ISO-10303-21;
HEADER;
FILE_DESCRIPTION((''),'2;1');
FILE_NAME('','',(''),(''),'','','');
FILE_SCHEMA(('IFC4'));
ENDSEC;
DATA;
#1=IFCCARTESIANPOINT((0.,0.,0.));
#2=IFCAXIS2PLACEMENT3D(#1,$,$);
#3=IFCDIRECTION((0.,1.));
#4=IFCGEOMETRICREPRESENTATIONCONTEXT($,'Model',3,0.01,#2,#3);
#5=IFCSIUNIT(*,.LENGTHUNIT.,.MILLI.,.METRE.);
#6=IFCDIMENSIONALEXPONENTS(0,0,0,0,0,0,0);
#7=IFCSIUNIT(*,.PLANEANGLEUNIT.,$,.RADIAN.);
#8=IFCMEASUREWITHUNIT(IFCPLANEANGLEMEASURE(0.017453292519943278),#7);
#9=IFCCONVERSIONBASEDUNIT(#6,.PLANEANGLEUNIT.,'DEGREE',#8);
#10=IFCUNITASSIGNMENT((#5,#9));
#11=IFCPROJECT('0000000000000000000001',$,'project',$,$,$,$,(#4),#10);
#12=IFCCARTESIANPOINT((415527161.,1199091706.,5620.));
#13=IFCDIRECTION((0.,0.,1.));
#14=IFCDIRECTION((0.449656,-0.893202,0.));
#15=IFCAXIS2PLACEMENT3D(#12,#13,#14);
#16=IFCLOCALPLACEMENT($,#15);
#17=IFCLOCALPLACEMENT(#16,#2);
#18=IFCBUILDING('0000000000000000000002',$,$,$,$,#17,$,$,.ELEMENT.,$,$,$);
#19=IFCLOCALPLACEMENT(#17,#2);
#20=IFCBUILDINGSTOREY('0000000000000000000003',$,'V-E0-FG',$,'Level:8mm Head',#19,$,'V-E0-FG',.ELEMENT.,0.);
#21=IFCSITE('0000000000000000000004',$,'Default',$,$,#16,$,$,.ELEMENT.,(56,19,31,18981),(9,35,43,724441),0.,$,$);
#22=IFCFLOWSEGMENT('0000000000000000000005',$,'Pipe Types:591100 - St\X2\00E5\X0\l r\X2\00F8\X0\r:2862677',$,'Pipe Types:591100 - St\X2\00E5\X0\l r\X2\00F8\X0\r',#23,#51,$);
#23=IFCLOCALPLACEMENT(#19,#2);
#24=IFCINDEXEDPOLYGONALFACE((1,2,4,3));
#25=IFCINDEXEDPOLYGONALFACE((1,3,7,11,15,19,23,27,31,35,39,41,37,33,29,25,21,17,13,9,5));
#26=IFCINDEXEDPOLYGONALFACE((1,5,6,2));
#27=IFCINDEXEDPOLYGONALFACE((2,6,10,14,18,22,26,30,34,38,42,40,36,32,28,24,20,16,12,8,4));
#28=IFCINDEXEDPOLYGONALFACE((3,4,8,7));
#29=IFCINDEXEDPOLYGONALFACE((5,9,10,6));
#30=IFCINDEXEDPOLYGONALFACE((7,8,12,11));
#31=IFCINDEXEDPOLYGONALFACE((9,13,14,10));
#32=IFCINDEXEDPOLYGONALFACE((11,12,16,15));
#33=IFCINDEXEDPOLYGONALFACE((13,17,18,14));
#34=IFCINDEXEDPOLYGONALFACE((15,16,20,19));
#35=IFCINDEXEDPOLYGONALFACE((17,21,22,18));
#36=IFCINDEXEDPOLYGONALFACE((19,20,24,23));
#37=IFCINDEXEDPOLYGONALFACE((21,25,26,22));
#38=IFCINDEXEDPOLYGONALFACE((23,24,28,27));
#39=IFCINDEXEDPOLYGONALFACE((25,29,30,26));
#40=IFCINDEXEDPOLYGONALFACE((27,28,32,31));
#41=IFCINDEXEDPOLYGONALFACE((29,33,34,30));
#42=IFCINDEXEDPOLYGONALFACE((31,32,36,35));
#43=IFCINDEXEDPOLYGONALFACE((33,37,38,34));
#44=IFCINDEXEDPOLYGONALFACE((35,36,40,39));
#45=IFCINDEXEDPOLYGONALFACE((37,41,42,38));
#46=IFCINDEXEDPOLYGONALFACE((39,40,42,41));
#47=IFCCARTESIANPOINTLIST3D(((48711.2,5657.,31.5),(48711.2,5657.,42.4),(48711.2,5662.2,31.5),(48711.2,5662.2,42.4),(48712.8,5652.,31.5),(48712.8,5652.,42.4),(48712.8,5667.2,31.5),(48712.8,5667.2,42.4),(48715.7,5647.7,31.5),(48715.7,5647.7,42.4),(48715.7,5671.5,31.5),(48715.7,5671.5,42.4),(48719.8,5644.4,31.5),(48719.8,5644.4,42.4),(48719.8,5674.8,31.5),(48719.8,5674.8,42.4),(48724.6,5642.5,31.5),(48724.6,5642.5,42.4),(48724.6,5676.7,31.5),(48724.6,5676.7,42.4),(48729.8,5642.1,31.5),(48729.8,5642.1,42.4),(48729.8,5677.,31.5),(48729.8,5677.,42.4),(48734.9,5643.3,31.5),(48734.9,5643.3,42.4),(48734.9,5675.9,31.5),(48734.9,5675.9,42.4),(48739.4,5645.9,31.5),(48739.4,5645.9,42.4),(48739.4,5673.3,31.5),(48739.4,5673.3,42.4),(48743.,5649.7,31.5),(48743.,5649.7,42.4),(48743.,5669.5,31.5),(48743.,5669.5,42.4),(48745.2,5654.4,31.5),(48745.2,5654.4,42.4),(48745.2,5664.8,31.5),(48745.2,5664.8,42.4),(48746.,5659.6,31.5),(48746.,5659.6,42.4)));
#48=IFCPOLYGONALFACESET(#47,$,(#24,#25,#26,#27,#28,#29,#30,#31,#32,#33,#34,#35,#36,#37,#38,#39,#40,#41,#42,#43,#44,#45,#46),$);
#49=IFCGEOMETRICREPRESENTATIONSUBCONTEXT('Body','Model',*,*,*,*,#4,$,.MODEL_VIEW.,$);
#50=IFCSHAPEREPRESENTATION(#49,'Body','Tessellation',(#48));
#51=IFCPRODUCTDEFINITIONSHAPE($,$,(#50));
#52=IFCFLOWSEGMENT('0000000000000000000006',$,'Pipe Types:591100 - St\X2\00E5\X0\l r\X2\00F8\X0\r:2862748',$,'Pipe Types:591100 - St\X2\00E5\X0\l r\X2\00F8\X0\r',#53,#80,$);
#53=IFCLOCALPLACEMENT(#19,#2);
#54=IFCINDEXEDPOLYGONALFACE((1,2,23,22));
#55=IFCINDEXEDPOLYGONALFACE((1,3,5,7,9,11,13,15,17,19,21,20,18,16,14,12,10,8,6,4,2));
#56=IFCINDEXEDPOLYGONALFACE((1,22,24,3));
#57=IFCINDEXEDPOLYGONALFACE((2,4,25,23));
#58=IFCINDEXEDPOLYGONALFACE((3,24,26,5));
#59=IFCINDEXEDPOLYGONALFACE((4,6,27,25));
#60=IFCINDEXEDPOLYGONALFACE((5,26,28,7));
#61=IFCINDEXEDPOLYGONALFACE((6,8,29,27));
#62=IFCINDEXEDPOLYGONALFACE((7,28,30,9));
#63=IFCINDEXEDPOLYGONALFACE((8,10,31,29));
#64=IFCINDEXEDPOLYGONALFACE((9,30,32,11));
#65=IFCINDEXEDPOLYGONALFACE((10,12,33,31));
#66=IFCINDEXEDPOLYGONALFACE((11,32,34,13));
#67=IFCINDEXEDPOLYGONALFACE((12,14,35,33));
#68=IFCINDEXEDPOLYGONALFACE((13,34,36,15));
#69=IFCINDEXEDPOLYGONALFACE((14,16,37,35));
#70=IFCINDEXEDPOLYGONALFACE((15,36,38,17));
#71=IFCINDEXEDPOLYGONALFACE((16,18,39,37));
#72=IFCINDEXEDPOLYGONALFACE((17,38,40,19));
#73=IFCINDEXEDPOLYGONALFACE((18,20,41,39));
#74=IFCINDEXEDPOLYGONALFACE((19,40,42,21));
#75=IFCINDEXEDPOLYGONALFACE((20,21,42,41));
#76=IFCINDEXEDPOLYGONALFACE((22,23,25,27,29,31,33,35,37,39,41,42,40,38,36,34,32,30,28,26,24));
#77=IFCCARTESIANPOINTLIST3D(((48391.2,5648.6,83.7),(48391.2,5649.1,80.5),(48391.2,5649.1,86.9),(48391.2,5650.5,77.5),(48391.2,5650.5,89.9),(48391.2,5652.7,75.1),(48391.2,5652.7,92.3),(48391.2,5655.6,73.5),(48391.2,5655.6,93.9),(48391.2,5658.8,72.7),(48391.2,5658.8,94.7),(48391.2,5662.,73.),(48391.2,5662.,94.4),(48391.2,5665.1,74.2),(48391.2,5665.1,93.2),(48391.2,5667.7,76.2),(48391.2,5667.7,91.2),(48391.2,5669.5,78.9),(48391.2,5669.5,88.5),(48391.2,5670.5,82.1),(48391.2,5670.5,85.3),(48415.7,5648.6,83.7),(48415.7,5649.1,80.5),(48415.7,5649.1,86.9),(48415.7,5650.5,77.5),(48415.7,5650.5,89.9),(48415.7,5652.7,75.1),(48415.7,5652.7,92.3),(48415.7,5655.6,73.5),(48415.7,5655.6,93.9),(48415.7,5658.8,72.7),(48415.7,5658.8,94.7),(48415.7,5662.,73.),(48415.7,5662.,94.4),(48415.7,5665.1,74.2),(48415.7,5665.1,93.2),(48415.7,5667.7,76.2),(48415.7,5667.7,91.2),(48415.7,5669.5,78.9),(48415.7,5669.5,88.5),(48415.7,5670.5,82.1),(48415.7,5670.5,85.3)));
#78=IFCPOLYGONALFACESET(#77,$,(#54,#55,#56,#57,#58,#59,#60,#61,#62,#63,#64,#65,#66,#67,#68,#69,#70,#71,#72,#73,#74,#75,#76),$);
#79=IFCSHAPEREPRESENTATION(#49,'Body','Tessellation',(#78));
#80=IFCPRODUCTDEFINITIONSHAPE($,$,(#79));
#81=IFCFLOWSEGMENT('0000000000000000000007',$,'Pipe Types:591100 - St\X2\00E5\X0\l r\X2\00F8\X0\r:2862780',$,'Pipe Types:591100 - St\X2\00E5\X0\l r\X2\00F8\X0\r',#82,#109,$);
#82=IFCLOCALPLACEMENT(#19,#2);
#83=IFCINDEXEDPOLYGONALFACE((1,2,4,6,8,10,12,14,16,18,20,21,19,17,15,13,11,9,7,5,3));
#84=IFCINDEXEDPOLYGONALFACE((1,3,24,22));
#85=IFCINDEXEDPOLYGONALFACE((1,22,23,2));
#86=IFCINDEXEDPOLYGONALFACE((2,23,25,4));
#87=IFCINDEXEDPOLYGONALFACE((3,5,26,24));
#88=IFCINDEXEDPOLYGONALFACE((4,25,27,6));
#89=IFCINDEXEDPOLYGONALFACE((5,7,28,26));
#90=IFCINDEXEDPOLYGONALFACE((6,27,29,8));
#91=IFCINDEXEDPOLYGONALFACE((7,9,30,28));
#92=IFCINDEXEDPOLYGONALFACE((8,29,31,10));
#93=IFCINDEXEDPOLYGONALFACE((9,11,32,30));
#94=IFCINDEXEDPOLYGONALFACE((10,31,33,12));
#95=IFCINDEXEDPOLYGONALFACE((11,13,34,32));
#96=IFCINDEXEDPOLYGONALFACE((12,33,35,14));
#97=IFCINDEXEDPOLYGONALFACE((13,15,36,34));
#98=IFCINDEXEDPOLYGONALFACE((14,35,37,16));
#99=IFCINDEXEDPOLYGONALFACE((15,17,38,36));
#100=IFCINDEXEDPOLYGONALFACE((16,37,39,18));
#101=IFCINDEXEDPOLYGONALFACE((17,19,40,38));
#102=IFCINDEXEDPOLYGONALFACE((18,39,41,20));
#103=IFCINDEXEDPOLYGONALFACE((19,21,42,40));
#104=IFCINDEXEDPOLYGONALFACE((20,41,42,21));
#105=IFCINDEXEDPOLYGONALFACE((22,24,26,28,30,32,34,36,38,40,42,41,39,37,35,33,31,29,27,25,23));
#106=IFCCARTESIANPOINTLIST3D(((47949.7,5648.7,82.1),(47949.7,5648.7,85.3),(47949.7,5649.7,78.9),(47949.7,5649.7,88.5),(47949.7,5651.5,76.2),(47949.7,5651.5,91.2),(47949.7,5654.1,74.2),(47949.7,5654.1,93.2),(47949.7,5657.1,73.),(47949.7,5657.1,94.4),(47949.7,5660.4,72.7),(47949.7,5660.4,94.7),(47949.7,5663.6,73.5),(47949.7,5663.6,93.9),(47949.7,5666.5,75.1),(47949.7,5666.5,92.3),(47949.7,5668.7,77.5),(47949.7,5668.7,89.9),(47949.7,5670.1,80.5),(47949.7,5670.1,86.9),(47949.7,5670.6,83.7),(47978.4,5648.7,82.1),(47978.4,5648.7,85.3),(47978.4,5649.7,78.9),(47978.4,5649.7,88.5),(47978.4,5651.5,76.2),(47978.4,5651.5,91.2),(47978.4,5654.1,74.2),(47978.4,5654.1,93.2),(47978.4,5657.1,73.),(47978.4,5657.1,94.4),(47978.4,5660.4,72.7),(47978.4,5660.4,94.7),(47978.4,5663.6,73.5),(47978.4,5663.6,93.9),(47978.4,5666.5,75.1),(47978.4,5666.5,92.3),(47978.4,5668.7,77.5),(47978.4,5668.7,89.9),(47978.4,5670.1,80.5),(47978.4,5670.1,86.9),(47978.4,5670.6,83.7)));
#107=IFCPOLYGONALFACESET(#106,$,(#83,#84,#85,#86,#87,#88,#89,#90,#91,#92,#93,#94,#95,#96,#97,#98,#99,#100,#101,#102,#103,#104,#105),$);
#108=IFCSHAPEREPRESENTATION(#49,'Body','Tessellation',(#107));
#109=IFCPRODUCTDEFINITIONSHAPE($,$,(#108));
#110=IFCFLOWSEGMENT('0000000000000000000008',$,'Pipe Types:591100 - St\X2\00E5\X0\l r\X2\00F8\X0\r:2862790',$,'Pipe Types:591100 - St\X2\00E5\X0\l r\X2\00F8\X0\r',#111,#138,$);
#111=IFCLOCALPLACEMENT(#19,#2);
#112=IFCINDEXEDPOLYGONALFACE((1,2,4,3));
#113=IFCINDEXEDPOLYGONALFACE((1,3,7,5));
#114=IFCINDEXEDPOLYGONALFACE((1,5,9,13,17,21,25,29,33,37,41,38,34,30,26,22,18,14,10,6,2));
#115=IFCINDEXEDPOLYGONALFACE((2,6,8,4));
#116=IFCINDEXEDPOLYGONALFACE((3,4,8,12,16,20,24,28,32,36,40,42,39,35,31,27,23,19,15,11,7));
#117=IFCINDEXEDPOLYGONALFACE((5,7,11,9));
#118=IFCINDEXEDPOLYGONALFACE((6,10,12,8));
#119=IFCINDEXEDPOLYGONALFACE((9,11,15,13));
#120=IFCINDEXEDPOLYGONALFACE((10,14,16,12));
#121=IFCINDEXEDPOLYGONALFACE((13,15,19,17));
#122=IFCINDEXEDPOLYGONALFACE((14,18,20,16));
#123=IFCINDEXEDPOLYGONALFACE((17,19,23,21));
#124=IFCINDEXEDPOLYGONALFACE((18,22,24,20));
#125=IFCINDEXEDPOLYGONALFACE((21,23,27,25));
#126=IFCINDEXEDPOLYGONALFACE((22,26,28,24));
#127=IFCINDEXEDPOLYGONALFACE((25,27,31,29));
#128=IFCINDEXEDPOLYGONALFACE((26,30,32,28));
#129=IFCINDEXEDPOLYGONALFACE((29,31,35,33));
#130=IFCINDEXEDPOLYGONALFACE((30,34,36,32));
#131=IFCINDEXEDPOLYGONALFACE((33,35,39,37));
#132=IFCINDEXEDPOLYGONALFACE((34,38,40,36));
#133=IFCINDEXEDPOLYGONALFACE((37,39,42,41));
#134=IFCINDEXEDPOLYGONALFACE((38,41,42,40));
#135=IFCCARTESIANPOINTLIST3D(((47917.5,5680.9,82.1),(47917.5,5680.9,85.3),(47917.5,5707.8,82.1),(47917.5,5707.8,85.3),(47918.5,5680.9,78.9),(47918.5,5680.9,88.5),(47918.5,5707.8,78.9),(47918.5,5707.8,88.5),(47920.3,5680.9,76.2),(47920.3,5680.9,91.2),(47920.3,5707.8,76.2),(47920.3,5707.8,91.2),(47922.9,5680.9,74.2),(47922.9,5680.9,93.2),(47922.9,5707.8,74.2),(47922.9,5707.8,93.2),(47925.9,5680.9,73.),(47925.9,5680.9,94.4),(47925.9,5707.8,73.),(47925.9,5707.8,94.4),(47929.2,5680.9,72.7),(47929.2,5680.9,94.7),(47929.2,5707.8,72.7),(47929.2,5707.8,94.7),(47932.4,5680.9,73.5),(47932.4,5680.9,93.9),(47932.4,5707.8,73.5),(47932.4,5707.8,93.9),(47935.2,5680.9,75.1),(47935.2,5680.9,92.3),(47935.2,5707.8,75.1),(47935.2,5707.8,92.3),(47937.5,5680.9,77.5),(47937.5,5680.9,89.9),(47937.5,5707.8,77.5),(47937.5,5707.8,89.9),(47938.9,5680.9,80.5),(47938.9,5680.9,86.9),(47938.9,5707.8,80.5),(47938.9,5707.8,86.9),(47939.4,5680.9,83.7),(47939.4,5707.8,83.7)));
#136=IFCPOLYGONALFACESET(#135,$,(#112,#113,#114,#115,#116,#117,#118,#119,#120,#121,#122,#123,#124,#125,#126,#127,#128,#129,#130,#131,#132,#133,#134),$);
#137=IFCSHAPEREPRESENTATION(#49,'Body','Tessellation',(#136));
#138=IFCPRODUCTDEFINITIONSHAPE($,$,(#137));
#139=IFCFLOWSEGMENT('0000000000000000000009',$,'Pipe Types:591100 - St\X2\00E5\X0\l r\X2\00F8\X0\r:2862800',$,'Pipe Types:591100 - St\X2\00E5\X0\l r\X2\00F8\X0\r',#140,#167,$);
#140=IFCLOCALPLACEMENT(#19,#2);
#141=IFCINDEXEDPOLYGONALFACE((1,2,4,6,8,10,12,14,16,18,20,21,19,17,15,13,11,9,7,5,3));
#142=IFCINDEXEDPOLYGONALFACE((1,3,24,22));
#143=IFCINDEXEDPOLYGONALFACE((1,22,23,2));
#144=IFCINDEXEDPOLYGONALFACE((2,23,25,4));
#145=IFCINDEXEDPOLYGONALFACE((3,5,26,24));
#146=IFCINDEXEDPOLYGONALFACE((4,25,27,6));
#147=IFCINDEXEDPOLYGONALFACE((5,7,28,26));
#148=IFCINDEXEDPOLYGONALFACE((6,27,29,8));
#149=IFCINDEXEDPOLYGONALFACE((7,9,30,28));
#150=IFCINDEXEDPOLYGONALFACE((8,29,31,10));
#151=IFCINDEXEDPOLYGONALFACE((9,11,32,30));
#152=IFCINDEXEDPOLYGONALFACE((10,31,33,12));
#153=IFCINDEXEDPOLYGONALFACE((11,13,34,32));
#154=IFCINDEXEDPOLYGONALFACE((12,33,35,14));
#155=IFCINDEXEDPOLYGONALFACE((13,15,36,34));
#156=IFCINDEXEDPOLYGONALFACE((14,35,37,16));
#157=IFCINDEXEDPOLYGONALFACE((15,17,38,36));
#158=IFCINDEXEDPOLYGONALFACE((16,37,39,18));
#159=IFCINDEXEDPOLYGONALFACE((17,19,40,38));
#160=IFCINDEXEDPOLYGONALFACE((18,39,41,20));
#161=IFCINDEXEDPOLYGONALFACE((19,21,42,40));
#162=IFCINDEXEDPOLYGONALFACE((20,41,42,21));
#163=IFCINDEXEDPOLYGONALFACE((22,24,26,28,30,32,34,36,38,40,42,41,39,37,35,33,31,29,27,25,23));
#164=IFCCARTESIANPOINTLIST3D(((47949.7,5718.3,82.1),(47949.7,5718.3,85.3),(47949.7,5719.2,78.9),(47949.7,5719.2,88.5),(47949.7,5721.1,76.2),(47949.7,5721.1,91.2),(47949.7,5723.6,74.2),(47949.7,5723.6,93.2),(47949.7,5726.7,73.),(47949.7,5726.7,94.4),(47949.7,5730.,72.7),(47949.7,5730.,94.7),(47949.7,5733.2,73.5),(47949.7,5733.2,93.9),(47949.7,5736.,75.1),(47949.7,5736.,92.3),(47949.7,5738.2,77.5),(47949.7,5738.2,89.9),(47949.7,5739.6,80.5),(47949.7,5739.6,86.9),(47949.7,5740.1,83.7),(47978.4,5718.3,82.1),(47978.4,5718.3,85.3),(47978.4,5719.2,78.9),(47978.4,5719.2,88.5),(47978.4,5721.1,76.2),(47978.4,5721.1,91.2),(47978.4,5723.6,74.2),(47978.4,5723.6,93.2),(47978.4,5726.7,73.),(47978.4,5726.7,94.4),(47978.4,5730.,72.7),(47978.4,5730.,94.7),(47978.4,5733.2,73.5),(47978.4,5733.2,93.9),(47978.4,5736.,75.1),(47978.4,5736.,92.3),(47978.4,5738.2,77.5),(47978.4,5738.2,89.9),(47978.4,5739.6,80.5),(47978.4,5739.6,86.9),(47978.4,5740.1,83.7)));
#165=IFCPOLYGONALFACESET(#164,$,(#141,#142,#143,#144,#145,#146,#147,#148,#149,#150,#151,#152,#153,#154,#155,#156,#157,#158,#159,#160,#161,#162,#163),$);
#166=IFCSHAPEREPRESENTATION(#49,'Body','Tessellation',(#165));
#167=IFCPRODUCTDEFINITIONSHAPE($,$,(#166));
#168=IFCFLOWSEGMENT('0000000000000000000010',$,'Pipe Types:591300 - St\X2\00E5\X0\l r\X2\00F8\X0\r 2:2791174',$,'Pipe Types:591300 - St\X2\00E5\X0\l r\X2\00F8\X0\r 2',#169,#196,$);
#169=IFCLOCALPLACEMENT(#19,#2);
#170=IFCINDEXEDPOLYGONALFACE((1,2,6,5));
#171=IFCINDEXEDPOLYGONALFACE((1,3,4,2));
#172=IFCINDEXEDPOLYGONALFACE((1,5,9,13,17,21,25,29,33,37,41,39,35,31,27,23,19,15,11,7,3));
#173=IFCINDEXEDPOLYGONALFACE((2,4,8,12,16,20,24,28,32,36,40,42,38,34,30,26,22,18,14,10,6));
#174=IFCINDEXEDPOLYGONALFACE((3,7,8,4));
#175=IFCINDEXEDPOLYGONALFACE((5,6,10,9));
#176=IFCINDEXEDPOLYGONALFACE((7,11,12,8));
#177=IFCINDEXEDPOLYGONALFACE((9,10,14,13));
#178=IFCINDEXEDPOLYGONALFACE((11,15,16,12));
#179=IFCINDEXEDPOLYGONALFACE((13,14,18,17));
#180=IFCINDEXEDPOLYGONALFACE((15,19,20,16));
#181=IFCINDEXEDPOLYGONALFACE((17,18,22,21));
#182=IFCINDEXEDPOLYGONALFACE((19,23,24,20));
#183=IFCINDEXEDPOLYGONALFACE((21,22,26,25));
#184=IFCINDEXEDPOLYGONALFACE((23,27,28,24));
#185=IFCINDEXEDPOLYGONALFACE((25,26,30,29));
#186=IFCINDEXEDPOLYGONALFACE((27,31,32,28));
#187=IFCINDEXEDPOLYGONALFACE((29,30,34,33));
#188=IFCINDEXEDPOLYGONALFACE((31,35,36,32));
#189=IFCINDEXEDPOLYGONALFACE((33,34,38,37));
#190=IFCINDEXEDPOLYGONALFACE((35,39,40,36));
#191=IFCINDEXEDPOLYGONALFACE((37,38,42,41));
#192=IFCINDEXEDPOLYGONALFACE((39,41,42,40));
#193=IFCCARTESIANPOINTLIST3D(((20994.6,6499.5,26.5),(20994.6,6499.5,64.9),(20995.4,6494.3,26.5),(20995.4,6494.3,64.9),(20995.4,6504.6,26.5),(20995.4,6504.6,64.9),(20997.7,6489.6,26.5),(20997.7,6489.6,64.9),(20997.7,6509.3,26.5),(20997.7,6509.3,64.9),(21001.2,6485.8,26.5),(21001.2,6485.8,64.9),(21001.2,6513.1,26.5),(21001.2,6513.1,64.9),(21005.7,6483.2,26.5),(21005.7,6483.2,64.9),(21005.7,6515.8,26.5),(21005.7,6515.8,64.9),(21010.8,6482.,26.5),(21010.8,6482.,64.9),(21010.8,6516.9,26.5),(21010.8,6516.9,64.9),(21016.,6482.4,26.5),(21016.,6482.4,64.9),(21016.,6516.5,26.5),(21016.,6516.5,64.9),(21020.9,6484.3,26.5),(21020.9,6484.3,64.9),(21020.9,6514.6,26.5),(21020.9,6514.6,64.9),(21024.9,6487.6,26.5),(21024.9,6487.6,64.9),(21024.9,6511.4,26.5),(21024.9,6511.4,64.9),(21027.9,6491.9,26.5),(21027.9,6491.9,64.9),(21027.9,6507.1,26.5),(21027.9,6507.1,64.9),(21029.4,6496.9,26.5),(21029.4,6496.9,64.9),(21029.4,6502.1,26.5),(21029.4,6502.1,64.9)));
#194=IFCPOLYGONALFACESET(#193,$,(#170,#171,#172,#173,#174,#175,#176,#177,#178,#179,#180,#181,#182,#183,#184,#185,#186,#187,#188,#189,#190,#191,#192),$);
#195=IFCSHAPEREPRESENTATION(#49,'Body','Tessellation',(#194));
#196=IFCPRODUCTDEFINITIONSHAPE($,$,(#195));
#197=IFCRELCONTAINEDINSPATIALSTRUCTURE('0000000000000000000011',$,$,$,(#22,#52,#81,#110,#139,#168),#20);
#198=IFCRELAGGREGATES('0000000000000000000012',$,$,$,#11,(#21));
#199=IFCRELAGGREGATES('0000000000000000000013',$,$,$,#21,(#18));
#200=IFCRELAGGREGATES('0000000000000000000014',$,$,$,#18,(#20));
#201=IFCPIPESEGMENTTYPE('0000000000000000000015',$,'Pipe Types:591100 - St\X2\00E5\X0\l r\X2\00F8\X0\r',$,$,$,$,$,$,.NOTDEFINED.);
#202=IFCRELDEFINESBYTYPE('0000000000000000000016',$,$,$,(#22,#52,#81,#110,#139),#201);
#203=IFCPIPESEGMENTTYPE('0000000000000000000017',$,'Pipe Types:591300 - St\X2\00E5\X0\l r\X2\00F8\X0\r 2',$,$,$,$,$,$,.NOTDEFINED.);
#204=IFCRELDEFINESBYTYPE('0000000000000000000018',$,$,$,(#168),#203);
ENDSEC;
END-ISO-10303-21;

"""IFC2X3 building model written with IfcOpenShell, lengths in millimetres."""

from ifc_helpers import new_model, entity, si_unit, converted_unit, direction, frame, frame_2d, origin, origin_2d_with_axis, place, context, subcontext, project, spatial, circle, extrude, type_object, element, save


model = new_model("IFC2X3")

# Units and contexts
model_context = context("Model", 3, precision=0.01, world=origin(), true_north=direction((0.0, 1.0)))
body_context = subcontext(model_context, "Body", "Model", "MODEL_VIEW")
ifc_project = project(units=[si_unit("LENGTHUNIT", "METRE", prefix="MILLI"), converted_unit("PLANEANGLEUNIT", "DEGREE", entity("IfcPlaneAngleMeasure", 0.017453292519943278), si_unit("PLANEANGLEUNIT", "RADIAN"), dimensions=[0, 0, 0, 0, 0, 0, 0])], contexts=[model_context])

# Site, building, storey
site_placement = place(None, frame((415527161.0, 1199091706.0, 5620.0), z_axis=(0.0, 0.0, 1.0), x_axis=(0.449656, -0.893202, 0.0)))
site = spatial("IfcSite", under=ifc_project, at=site_placement, Name="Default", CompositionType="ELEMENT", RefLatitude=(56, 19, 31, 18981), RefLongitude=(9, 35, 43, 724441), RefElevation=0.0)
building_placement = place(site_placement, origin())
building = spatial("IfcBuilding", under=site, at=building_placement, CompositionType="ELEMENT")
storey_placement = place(building_placement, origin())
storey = spatial("IfcBuildingStorey", under=building, at=storey_placement, Name="V-E0-FG", ObjectType="Level:8mm Head", LongName="V-E0-FG", CompositionType="ELEMENT", Elevation=0.0)

# Flow segments
pipe_segment_type_1 = type_object("IfcPipeSegmentType", Name="Pipe Types:591100 - Stål rør", PredefinedType="NOTDEFINED")
flow_segment_1_placement = place(storey_placement, origin())
element("IfcFlowSegment", 1, at=flow_segment_1_placement, inside=storey, type_object=pipe_segment_type_1, Name="Pipe Types:591100 - Stål rør:2862677", ObjectType="Pipe Types:591100 - Stål rør", context=body_context, shape_type="SweptSolid", body=[
    extrude(circle(Radius=17.5, at=origin_2d_with_axis()), frame((48728.5, 5659.6, 31.5)), (0.0, 0.0, 1.0), 10.9),
])
flow_segment_2_placement = place(storey_placement, origin())
element("IfcFlowSegment", 2, at=flow_segment_2_placement, inside=storey, type_object=pipe_segment_type_1, Name="Pipe Types:591100 - Stål rør:2862748", ObjectType="Pipe Types:591100 - Stål rør", context=body_context, shape_type="SweptSolid", body=[
    extrude(circle(Radius=11.0, at=origin_2d_with_axis()), frame((48391.2, 5659.6, 83.7), z_axis=(1.0, 0.0, 0.0), x_axis=(0.0, -1.0, 0.0)), (0.0, 0.0, 1.0), 24.5),
])
flow_segment_3_placement = place(storey_placement, origin())
element("IfcFlowSegment", 3, at=flow_segment_3_placement, inside=storey, type_object=pipe_segment_type_1, Name="Pipe Types:591100 - Stål rør:2862780", ObjectType="Pipe Types:591100 - Stål rør", context=body_context, shape_type="SweptSolid", body=[
    extrude(circle(Radius=11.0, at=frame_2d((0.0, 0.0), x_axis=(1.0, 0.0))), frame((47949.7, 5659.6, 83.7), z_axis=(1.0, 0.0, 0.0), x_axis=(0.0, 1.0, 0.0)), (0.0, 0.0, 1.0), 28.7),
])
flow_segment_4_placement = place(storey_placement, origin())
element("IfcFlowSegment", 4, at=flow_segment_4_placement, inside=storey, type_object=pipe_segment_type_1, Name="Pipe Types:591100 - Stål rør:2862790", ObjectType="Pipe Types:591100 - Stål rør", context=body_context, shape_type="SweptSolid", body=[
    extrude(circle(Radius=11.0, at=frame_2d((0.0, 0.0), x_axis=(1.0, 0.0))), frame((47928.4, 5680.9, 83.7), z_axis=(0.0, 1.0, 0.0), x_axis=(1.0, 0.0, 0.0)), (0.0, 0.0, 1.0), 26.8),
])
flow_segment_5_placement = place(storey_placement, origin())
element("IfcFlowSegment", 5, at=flow_segment_5_placement, inside=storey, type_object=pipe_segment_type_1, Name="Pipe Types:591100 - Stål rør:2862800", ObjectType="Pipe Types:591100 - Stål rør", context=body_context, shape_type="SweptSolid", body=[
    extrude(circle(Radius=11.0, at=frame_2d((0.0, 0.0), x_axis=(1.0, 0.0))), frame((47949.7, 5729.1, 83.7), z_axis=(1.0, 0.0, 0.0), x_axis=(0.0, 1.0, 0.0)), (0.0, 0.0, 1.0), 28.7),
])
pipe_segment_type_2 = type_object("IfcPipeSegmentType", Name="Pipe Types:591300 - Stål rør 2", PredefinedType="NOTDEFINED")
flow_segment_6_placement = place(storey_placement, origin())
element("IfcFlowSegment", 6, at=flow_segment_6_placement, inside=storey, type_object=pipe_segment_type_2, Name="Pipe Types:591300 - Stål rør 2:2791174", ObjectType="Pipe Types:591300 - Stål rør 2", context=body_context, shape_type="SweptSolid", body=[
    extrude(circle(Radius=17.5, at=origin_2d_with_axis()), frame((21012.1, 6499.5, 26.5), z_axis=(0.0, 0.0, 1.0), x_axis=(-1.0, 0.0, 0.0)), (0.0, 0.0, 1.0), 38.4),
])

save(model, "model.ifc")
